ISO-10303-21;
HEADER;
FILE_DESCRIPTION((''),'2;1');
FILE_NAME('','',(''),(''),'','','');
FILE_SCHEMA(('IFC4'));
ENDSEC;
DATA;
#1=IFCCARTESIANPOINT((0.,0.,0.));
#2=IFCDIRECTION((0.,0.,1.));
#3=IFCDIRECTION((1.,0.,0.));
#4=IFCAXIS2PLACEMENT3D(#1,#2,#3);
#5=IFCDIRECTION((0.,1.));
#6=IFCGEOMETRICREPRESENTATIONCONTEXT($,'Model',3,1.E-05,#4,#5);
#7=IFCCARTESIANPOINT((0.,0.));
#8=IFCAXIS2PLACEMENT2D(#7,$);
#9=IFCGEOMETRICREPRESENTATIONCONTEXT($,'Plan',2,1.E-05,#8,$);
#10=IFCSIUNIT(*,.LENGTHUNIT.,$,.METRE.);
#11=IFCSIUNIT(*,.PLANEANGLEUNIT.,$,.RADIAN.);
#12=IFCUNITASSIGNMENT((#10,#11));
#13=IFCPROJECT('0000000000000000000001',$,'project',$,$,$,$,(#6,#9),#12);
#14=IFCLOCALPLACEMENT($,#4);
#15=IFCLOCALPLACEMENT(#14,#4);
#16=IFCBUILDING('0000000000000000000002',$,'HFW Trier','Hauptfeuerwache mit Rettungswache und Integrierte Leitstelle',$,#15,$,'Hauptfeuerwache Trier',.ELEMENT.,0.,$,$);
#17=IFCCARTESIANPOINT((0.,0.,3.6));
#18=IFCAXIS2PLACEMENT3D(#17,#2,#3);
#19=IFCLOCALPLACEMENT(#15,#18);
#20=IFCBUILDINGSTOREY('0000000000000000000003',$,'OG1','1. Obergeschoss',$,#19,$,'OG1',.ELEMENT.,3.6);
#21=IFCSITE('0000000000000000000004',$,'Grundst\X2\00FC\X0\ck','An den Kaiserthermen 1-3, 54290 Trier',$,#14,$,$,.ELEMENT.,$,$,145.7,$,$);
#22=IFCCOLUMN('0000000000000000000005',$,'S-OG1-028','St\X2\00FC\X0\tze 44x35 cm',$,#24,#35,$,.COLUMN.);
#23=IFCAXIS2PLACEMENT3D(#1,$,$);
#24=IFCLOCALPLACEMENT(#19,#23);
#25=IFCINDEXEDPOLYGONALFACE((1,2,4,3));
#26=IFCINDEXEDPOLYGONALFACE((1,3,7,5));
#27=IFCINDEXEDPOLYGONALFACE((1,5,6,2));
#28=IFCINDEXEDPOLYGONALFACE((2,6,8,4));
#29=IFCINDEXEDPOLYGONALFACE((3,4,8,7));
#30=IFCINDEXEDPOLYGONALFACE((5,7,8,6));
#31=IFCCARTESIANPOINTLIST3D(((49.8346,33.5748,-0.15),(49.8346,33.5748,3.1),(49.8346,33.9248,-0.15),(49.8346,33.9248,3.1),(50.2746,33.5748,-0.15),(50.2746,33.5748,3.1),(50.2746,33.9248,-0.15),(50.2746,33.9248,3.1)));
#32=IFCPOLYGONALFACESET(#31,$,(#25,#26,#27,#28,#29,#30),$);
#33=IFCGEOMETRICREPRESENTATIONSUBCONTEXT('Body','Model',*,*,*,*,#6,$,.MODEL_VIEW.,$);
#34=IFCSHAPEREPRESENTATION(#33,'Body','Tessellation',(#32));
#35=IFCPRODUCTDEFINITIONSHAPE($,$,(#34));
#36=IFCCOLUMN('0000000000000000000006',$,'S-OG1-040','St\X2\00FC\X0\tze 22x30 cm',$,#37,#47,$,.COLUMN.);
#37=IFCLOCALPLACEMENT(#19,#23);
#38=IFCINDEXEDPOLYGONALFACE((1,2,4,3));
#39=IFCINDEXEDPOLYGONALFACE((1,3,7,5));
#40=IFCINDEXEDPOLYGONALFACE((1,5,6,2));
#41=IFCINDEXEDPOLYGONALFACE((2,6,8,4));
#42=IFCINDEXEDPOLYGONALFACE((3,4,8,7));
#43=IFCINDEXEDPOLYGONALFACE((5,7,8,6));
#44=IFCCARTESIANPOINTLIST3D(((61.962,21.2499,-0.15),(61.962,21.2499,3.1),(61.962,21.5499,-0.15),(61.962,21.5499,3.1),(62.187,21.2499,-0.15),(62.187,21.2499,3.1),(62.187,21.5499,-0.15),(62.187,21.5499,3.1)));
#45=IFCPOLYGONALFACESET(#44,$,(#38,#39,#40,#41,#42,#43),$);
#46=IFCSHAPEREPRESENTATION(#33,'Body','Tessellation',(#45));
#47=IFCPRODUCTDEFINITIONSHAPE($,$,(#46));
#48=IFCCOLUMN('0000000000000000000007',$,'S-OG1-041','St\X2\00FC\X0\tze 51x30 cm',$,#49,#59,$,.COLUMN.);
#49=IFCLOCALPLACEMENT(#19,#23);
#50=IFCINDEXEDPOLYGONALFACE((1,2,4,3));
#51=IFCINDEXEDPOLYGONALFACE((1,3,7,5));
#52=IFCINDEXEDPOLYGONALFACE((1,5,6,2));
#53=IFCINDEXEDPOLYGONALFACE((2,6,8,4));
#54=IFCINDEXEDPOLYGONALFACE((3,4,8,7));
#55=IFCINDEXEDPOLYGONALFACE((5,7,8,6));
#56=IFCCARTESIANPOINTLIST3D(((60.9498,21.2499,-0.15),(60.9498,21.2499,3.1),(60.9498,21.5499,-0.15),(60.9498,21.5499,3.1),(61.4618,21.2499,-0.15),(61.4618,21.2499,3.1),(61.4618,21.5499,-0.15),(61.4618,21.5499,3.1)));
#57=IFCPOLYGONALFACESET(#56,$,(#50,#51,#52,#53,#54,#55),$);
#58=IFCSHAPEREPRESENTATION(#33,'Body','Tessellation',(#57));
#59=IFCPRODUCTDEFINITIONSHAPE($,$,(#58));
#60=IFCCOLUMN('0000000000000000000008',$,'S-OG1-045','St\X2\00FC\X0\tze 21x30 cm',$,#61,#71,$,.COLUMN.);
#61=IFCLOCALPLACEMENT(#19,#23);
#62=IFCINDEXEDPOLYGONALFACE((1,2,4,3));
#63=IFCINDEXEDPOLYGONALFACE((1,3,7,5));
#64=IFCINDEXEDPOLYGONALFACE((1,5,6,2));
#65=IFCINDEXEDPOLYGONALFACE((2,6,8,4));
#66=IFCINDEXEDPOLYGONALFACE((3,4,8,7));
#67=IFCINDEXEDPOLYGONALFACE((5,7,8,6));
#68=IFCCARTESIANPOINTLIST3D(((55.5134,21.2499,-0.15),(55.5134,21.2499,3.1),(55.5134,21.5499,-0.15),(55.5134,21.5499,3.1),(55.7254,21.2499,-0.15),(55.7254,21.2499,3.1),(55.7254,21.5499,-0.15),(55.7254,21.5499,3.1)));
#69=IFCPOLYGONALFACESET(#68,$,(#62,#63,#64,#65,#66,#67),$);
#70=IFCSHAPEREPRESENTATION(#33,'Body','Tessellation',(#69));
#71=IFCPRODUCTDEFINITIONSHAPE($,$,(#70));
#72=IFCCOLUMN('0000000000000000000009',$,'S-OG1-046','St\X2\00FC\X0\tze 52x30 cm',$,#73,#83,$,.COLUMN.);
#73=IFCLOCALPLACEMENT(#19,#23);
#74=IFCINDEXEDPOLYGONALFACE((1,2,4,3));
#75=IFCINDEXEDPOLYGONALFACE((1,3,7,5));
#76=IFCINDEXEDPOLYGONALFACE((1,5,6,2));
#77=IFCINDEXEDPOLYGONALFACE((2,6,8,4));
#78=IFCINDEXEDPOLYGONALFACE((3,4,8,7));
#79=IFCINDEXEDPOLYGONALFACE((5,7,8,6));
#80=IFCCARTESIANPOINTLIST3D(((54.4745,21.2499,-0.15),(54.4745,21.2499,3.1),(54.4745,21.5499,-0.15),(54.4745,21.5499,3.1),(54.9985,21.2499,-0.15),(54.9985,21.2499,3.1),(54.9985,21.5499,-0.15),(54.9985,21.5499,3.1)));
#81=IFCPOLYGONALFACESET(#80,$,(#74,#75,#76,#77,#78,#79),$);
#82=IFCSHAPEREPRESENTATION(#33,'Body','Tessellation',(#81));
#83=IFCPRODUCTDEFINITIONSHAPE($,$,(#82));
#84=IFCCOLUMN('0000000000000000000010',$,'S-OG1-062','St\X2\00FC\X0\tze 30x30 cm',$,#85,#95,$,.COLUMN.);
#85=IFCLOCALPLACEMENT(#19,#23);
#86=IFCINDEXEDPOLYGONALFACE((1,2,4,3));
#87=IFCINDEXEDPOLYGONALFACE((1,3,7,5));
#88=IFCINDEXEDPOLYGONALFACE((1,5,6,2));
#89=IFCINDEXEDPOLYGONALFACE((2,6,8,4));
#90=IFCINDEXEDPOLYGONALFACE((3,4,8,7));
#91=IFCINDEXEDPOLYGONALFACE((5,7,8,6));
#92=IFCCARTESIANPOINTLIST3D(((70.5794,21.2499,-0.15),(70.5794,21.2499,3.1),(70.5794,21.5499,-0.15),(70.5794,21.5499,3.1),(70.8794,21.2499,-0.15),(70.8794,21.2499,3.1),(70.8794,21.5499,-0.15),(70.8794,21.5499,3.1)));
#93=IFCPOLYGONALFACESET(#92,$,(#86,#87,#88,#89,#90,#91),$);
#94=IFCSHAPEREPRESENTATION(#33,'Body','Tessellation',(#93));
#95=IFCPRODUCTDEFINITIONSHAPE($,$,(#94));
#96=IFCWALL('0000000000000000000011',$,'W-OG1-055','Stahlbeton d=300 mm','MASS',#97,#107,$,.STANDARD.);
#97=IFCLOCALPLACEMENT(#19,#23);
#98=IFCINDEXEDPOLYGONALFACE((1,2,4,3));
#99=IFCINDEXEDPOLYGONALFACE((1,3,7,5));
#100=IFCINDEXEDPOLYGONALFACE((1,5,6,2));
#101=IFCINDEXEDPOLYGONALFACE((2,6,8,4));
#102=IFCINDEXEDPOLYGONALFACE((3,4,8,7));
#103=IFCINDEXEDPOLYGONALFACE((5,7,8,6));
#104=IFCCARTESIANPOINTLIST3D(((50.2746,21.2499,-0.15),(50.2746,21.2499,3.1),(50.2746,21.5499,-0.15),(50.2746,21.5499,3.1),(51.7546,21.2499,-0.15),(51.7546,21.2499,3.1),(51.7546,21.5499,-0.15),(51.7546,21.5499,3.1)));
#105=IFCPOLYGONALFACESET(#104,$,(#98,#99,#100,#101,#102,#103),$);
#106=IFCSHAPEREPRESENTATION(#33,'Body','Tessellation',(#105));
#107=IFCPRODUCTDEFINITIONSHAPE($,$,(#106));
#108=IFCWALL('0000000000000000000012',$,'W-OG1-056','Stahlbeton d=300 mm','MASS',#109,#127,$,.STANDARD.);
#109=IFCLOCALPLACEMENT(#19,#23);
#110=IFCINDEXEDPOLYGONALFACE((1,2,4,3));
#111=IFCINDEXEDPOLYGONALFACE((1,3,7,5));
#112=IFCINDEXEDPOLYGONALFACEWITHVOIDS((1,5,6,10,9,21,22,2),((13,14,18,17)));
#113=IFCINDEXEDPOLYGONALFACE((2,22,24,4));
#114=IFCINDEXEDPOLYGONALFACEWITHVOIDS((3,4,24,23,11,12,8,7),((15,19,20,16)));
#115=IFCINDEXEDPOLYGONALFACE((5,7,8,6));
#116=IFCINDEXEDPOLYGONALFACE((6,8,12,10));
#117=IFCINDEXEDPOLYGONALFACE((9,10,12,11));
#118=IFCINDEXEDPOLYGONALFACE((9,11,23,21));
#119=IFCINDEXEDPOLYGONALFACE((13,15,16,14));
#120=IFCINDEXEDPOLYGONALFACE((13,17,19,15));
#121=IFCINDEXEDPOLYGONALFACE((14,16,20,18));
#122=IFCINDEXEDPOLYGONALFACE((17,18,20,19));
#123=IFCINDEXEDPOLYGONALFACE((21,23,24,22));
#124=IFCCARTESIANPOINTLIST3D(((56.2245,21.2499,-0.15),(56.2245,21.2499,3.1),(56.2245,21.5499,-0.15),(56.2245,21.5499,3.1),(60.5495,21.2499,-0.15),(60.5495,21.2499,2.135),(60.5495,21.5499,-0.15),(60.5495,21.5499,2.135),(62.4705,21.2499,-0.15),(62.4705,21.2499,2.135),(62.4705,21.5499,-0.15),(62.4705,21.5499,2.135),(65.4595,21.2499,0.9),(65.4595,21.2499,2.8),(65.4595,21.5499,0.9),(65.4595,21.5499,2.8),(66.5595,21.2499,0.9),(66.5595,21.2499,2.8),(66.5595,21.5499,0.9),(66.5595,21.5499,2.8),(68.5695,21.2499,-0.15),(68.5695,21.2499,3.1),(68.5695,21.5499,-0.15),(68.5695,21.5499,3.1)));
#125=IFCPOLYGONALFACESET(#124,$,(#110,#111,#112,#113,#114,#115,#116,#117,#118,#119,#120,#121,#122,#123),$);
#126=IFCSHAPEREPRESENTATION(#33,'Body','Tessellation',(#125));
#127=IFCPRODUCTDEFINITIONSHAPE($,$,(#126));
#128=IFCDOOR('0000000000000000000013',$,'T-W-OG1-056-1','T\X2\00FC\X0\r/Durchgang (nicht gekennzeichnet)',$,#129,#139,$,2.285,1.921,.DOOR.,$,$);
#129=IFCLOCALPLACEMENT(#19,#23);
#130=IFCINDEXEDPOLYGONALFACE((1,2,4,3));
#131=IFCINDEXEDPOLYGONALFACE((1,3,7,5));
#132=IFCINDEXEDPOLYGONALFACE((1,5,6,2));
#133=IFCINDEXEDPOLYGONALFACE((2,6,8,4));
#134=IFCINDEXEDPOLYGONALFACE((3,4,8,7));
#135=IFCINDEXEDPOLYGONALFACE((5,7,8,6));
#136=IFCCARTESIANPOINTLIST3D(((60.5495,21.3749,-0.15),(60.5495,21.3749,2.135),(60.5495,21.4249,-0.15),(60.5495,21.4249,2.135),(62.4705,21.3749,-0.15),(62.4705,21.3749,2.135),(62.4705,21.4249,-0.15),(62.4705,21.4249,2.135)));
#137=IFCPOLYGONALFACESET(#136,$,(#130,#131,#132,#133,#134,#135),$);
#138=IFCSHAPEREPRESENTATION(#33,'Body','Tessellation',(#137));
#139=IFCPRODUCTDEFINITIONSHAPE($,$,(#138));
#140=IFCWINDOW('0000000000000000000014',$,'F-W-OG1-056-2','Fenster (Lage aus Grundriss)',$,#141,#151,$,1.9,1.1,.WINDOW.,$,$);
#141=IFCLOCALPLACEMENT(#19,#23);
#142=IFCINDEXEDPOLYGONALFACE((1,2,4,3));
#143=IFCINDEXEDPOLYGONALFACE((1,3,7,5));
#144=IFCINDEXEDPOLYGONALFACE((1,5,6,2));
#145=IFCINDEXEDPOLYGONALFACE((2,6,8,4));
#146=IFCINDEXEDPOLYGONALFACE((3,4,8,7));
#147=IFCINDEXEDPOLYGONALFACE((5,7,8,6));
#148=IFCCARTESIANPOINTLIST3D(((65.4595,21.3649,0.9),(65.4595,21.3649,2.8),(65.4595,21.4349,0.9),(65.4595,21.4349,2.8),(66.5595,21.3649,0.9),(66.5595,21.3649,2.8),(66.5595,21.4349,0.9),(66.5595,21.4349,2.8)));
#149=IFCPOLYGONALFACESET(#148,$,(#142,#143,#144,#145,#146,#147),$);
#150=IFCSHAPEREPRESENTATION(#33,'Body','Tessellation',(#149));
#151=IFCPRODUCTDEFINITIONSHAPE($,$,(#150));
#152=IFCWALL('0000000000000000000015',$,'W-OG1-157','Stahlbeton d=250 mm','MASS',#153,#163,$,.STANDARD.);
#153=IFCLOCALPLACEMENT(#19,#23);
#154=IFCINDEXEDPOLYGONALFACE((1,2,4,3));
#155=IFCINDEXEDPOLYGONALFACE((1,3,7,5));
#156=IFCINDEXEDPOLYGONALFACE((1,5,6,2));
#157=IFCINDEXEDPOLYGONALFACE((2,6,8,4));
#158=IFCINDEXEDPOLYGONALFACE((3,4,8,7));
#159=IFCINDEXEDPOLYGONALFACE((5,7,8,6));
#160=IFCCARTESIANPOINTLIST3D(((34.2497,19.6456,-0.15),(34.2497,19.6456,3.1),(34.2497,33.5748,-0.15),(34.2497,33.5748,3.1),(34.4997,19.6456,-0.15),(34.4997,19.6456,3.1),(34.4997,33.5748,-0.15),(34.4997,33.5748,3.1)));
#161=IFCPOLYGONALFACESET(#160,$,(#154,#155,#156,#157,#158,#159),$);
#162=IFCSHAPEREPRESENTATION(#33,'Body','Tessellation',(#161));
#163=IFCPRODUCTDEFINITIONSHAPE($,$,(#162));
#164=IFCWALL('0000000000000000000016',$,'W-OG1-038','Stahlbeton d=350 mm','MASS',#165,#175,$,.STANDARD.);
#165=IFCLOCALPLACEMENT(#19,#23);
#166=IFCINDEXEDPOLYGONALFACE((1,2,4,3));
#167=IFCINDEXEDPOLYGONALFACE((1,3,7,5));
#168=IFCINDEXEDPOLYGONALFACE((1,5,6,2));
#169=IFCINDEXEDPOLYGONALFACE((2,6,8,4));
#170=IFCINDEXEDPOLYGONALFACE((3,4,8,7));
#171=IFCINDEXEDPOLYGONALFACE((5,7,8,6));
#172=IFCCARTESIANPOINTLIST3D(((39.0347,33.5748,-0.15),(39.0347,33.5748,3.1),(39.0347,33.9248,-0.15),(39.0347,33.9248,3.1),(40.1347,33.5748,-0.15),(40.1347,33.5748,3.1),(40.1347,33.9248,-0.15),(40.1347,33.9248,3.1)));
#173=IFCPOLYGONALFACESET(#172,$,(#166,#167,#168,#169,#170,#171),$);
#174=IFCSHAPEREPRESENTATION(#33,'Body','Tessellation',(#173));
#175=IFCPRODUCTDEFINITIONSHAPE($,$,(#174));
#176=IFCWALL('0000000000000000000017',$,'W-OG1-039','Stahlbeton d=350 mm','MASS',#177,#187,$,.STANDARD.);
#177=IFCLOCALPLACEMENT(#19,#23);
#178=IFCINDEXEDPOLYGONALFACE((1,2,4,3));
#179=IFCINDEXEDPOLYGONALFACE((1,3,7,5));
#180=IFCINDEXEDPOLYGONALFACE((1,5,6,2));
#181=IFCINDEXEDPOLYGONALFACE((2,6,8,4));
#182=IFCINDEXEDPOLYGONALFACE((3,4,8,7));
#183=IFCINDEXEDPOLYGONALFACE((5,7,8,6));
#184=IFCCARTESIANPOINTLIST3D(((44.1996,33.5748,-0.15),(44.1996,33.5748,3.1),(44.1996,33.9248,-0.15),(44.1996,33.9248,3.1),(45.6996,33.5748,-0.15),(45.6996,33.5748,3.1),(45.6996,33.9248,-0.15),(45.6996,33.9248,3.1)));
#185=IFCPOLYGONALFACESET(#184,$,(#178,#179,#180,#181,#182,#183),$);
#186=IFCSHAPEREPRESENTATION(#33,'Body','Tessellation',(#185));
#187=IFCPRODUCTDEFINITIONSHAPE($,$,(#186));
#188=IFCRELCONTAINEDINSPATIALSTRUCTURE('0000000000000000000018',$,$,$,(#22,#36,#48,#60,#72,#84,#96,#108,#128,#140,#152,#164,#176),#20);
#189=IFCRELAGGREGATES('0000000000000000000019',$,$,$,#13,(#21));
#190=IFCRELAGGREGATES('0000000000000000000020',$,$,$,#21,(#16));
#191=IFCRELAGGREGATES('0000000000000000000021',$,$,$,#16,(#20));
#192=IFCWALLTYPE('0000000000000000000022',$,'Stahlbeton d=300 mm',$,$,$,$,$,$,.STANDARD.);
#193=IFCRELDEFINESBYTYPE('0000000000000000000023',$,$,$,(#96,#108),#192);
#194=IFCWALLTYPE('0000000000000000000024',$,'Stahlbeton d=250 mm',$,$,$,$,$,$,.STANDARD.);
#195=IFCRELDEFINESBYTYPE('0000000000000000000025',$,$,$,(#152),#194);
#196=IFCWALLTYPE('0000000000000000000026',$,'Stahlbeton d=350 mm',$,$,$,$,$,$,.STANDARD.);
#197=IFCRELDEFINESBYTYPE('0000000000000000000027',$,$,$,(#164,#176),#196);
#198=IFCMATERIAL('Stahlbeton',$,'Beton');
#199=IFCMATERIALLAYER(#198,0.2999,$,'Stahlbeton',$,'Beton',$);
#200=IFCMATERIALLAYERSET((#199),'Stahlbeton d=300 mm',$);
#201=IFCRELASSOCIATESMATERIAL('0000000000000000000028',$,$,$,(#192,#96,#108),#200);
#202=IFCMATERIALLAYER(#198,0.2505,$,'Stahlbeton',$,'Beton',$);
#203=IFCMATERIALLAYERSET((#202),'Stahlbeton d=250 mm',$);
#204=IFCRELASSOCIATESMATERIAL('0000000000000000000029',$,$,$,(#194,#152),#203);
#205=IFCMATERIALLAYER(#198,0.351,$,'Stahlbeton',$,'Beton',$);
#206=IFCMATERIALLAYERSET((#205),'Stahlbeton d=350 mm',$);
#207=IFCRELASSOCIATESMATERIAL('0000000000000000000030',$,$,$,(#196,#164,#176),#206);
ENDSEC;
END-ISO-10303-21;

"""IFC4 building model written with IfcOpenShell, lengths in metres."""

from ifc_helpers import new_model, si_unit, direction, frame, frame_2d, origin_with_axes, origin_2d, place, context, subcontext, project, spatial, rectangle, extrude, material, layer, layer_set, layer_usage, type_object, element, fill, save


model = new_model("IFC4")

# Units and contexts
model_context = context("Model", 3, precision=1e-05, world=origin_with_axes(), true_north=direction((0.0, 1.0)))
plan_context = context("Plan", 2, precision=1e-05, world=origin_2d())
body_context = subcontext(model_context, "Body", "Model", "MODEL_VIEW")
ifc_project = project(units=[si_unit("LENGTHUNIT", "METRE"), si_unit("PLANEANGLEUNIT", "RADIAN")], contexts=[model_context, plan_context])

# Site, building, storey
site_placement = place(None, origin_with_axes())
site = spatial("IfcSite", under=ifc_project, at=site_placement, Name="Grundstück", Description="An den Kaiserthermen 1-3, 54290 Trier", CompositionType="ELEMENT", RefElevation=145.7)
building_placement = place(site_placement, origin_with_axes())
building = spatial("IfcBuilding", under=site, at=building_placement, Name="HFW Trier", Description="Hauptfeuerwache mit Rettungswache und Integrierte Leitstelle", LongName="Hauptfeuerwache Trier", CompositionType="ELEMENT", ElevationOfRefHeight=0.0)
storey_placement = place(building_placement, frame((0.0, 0.0, 3.6), z_axis=(0.0, 0.0, 1.0), x_axis=(1.0, 0.0, 0.0)))
storey = spatial("IfcBuildingStorey", under=building, at=storey_placement, Name="OG1", Description="1. Obergeschoss", LongName="OG1", CompositionType="ELEMENT", Elevation=3.6)

# Columns
column_1_placement = place(storey_placement, frame((49.8346, 33.7498, -0.15), z_axis=(0.0, 0.0, 1.0), x_axis=(1.0, 0.0, 0.0)))
element("IfcColumn", 1, at=column_1_placement, inside=storey, Name="S-OG1-028", Description="Stütze 44x35 cm", PredefinedType="COLUMN", context=body_context, shape_type="SweptSolid", body=[
    extrude(rectangle(XDim=0.44, YDim=0.35, at=frame_2d((0.22, 0.0))), origin_with_axes(), (0.0, 0.0, 1.0), 3.25),
])
column_2_placement = place(storey_placement, frame((61.962, 21.3999, -0.15), z_axis=(0.0, 0.0, 1.0), x_axis=(1.0, 0.0, 0.0)))
element("IfcColumn", 2, at=column_2_placement, inside=storey, Name="S-OG1-040", Description="Stütze 22x30 cm", PredefinedType="COLUMN", context=body_context, shape_type="SweptSolid", body=[
    extrude(rectangle(XDim=0.225, YDim=0.3, at=frame_2d((0.1125, 0.0))), origin_with_axes(), (0.0, 0.0, 1.0), 3.25),
])
column_3_placement = place(storey_placement, frame((60.9498, 21.3999, -0.15), z_axis=(0.0, 0.0, 1.0), x_axis=(1.0, 0.0, 0.0)))
element("IfcColumn", 3, at=column_3_placement, inside=storey, Name="S-OG1-041", Description="Stütze 51x30 cm", PredefinedType="COLUMN", context=body_context, shape_type="SweptSolid", body=[
    extrude(rectangle(XDim=0.512, YDim=0.3, at=frame_2d((0.256, 0.0))), origin_with_axes(), (0.0, 0.0, 1.0), 3.25),
])
column_4_placement = place(storey_placement, frame((55.5134, 21.3999, -0.15), z_axis=(0.0, 0.0, 1.0), x_axis=(1.0, 0.0, 0.0)))
element("IfcColumn", 4, at=column_4_placement, inside=storey, Name="S-OG1-045", Description="Stütze 21x30 cm", PredefinedType="COLUMN", context=body_context, shape_type="SweptSolid", body=[
    extrude(rectangle(XDim=0.212, YDim=0.3, at=frame_2d((0.106, 0.0))), origin_with_axes(), (0.0, 0.0, 1.0), 3.25),
])
column_5_placement = place(storey_placement, frame((54.4745, 21.3999, -0.15), z_axis=(0.0, 0.0, 1.0), x_axis=(1.0, 0.0, 0.0)))
element("IfcColumn", 5, at=column_5_placement, inside=storey, Name="S-OG1-046", Description="Stütze 52x30 cm", PredefinedType="COLUMN", context=body_context, shape_type="SweptSolid", body=[
    extrude(rectangle(XDim=0.524, YDim=0.3, at=frame_2d((0.262, 0.0))), origin_with_axes(), (0.0, 0.0, 1.0), 3.25),
])
column_6_placement = place(storey_placement, frame((70.5794, 21.3999, -0.15), z_axis=(0.0, 0.0, 1.0), x_axis=(1.0, 0.0, 0.0)))
element("IfcColumn", 6, at=column_6_placement, inside=storey, Name="S-OG1-062", Description="Stütze 30x30 cm", PredefinedType="COLUMN", context=body_context, shape_type="SweptSolid", body=[
    extrude(rectangle(XDim=0.3, YDim=0.3, at=frame_2d((0.15, 0.0))), origin_with_axes(), (0.0, 0.0, 1.0), 3.25),
])

# Wall
ifc_material = material(Name="Stahlbeton", Category="Beton")
ifc_layer_1 = layer(ifc_material, 0.2999, Name="Stahlbeton", Category="Beton")
ifc_layer_set_1 = layer_set([ifc_layer_1], Name="Stahlbeton d=300 mm")
ifc_layer_usage_1 = layer_usage(ifc_layer_set_1, "AXIS2", "POSITIVE", -0.15)
wall_type_1 = type_object("IfcWallType", Name="Stahlbeton d=300 mm", PredefinedType="STANDARD", material=ifc_layer_set_1)
wall_1_placement = place(storey_placement, frame((50.2746, 21.3999, -0.15), z_axis=(0.0, 0.0, 1.0), x_axis=(1.0, 0.0, 0.0)))
element("IfcWall", 7, at=wall_1_placement, inside=storey, type_object=wall_type_1, material=ifc_layer_usage_1, Name="W-OG1-055", Description="Stahlbeton d=300 mm", ObjectType="MASS", PredefinedType="STANDARD", context=body_context, shape_type="SweptSolid", body=[
    extrude(rectangle(XDim=1.48, YDim=0.3, at=frame_2d((0.74, 0.0))), origin_with_axes(), (0.0, 0.0, 1.0), 3.25),
])

# Wall, openings, door, window
ifc_layer_usage_2 = layer_usage(ifc_layer_set_1, "AXIS2", "POSITIVE", -0.15)
wall_2_placement = place(storey_placement, frame((56.2245, 21.3999, -0.15), z_axis=(0.0, 0.0, 1.0), x_axis=(1.0, 0.0, 0.0)))
wall_2 = element("IfcWall", 8, at=wall_2_placement, inside=storey, type_object=wall_type_1, material=ifc_layer_usage_2, Name="W-OG1-056", Description="Stahlbeton d=300 mm", ObjectType="MASS", PredefinedType="STANDARD", context=body_context, shape_type="SweptSolid", body=[
    extrude(rectangle(XDim=12.345, YDim=0.3, at=frame_2d((6.1725, 0.0))), origin_with_axes(), (0.0, 0.0, 1.0), 3.25),
])
opening_1_placement = place(wall_2_placement, frame((4.325, 0.0, 0.0), z_axis=(0.0, 0.0, 1.0), x_axis=(1.0, 0.0, 0.0)))
opening_1 = element("IfcOpeningElement", 9, at=opening_1_placement, cuts=wall_2, PredefinedType="OPENING", context=body_context, shape_type="SweptSolid", body=[
    extrude(rectangle(XDim=1.921, YDim=0.4, at=frame_2d((0.9605, 0.0))), origin_with_axes(), (0.0, 0.0, 1.0), 2.285),
])
opening_2_placement = place(wall_2_placement, frame((9.235, 0.0, 0.0), z_axis=(0.0, 0.0, 1.0), x_axis=(1.0, 0.0, 0.0)))
opening_2 = element("IfcOpeningElement", 10, at=opening_2_placement, cuts=wall_2, PredefinedType="OPENING", context=body_context, shape_type="SweptSolid", body=[
    extrude(rectangle(XDim=1.1, YDim=0.4, at=frame_2d((0.55, 0.0))), frame((0.0, 0.0, 1.05), z_axis=(0.0, 0.0, 1.0), x_axis=(1.0, 0.0, 0.0)), (0.0, 0.0, 1.0), 1.9),
])
door_1_placement = place(wall_2_placement, frame((4.325, 0.0, 0.0), z_axis=(0.0, 0.0, 1.0), x_axis=(1.0, 0.0, 0.0)))
door_1 = element("IfcDoor", 11, at=door_1_placement, inside=storey, Name="T-W-OG1-056-1", Description="Tür/Durchgang (nicht gekennzeichnet)", OverallHeight=2.285, OverallWidth=1.921, PredefinedType="DOOR", context=body_context, shape_type="SweptSolid", body=[
    extrude(rectangle(XDim=1.921, YDim=0.05, at=frame_2d((0.9605, 0.0))), origin_with_axes(), (0.0, 0.0, 1.0), 2.285),
])
fill(opening_1, door_1)
window_placement = place(wall_2_placement, frame((9.235, 0.0, 0.0), z_axis=(0.0, 0.0, 1.0), x_axis=(1.0, 0.0, 0.0)))
window = element("IfcWindow", 12, at=window_placement, inside=storey, Name="F-W-OG1-056-2", Description="Fenster (Lage aus Grundriss)", OverallHeight=1.9, OverallWidth=1.1, PredefinedType="WINDOW", context=body_context, shape_type="SweptSolid", body=[
    extrude(rectangle(XDim=1.1, YDim=0.07, at=frame_2d((0.55, 0.0))), frame((0.0, 0.0, 1.05), z_axis=(0.0, 0.0, 1.0), x_axis=(1.0, 0.0, 0.0)), (0.0, 0.0, 1.0), 1.9),
])
fill(opening_2, window)

# Walls
ifc_layer_2 = layer(ifc_material, 0.2505, Name="Stahlbeton", Category="Beton")
ifc_layer_set_2 = layer_set([ifc_layer_2], Name="Stahlbeton d=250 mm")
ifc_layer_usage_3 = layer_usage(ifc_layer_set_2, "AXIS2", "POSITIVE", -0.125)
wall_type_2 = type_object("IfcWallType", Name="Stahlbeton d=250 mm", PredefinedType="STANDARD", material=ifc_layer_set_2)
wall_3_placement = place(storey_placement, frame((34.3747, 33.5748, -0.15), z_axis=(0.0, 0.0, 1.0), x_axis=(0.0, -1.0, 0.0)))
element("IfcWall", 13, at=wall_3_placement, inside=storey, type_object=wall_type_2, material=ifc_layer_usage_3, Name="W-OG1-157", Description="Stahlbeton d=250 mm", ObjectType="MASS", PredefinedType="STANDARD", context=body_context, shape_type="SweptSolid", body=[
    extrude(rectangle(XDim=13.9292, YDim=0.25, at=frame_2d((6.9646, 0.0))), origin_with_axes(), (0.0, 0.0, 1.0), 3.25),
])
ifc_layer_3 = layer(ifc_material, 0.351, Name="Stahlbeton", Category="Beton")
ifc_layer_set_3 = layer_set([ifc_layer_3], Name="Stahlbeton d=350 mm")
ifc_layer_usage_4 = layer_usage(ifc_layer_set_3, "AXIS2", "POSITIVE", -0.175)
wall_type_3 = type_object("IfcWallType", Name="Stahlbeton d=350 mm", PredefinedType="STANDARD", material=ifc_layer_set_3)
wall_4_placement = place(storey_placement, frame((39.0347, 33.7498, -0.15), z_axis=(0.0, 0.0, 1.0), x_axis=(1.0, 0.0, 0.0)))
element("IfcWall", 14, at=wall_4_placement, inside=storey, type_object=wall_type_3, material=ifc_layer_usage_4, Name="W-OG1-038", Description="Stahlbeton d=350 mm", ObjectType="MASS", PredefinedType="STANDARD", context=body_context, shape_type="SweptSolid", body=[
    extrude(rectangle(XDim=1.1, YDim=0.35, at=frame_2d((0.55, 0.0))), origin_with_axes(), (0.0, 0.0, 1.0), 3.25),
])
ifc_layer_usage_5 = layer_usage(ifc_layer_set_3, "AXIS2", "POSITIVE", -0.175)
wall_5_placement = place(storey_placement, frame((44.1996, 33.7498, -0.15), z_axis=(0.0, 0.0, 1.0), x_axis=(1.0, 0.0, 0.0)))
element("IfcWall", 15, at=wall_5_placement, inside=storey, type_object=wall_type_3, material=ifc_layer_usage_5, Name="W-OG1-039", Description="Stahlbeton d=350 mm", ObjectType="MASS", PredefinedType="STANDARD", context=body_context, shape_type="SweptSolid", body=[
    extrude(rectangle(XDim=1.5, YDim=0.35, at=frame_2d((0.75, 0.0))), origin_with_axes(), (0.0, 0.0, 1.0), 3.25),
])

save(model, "model.ifc")
